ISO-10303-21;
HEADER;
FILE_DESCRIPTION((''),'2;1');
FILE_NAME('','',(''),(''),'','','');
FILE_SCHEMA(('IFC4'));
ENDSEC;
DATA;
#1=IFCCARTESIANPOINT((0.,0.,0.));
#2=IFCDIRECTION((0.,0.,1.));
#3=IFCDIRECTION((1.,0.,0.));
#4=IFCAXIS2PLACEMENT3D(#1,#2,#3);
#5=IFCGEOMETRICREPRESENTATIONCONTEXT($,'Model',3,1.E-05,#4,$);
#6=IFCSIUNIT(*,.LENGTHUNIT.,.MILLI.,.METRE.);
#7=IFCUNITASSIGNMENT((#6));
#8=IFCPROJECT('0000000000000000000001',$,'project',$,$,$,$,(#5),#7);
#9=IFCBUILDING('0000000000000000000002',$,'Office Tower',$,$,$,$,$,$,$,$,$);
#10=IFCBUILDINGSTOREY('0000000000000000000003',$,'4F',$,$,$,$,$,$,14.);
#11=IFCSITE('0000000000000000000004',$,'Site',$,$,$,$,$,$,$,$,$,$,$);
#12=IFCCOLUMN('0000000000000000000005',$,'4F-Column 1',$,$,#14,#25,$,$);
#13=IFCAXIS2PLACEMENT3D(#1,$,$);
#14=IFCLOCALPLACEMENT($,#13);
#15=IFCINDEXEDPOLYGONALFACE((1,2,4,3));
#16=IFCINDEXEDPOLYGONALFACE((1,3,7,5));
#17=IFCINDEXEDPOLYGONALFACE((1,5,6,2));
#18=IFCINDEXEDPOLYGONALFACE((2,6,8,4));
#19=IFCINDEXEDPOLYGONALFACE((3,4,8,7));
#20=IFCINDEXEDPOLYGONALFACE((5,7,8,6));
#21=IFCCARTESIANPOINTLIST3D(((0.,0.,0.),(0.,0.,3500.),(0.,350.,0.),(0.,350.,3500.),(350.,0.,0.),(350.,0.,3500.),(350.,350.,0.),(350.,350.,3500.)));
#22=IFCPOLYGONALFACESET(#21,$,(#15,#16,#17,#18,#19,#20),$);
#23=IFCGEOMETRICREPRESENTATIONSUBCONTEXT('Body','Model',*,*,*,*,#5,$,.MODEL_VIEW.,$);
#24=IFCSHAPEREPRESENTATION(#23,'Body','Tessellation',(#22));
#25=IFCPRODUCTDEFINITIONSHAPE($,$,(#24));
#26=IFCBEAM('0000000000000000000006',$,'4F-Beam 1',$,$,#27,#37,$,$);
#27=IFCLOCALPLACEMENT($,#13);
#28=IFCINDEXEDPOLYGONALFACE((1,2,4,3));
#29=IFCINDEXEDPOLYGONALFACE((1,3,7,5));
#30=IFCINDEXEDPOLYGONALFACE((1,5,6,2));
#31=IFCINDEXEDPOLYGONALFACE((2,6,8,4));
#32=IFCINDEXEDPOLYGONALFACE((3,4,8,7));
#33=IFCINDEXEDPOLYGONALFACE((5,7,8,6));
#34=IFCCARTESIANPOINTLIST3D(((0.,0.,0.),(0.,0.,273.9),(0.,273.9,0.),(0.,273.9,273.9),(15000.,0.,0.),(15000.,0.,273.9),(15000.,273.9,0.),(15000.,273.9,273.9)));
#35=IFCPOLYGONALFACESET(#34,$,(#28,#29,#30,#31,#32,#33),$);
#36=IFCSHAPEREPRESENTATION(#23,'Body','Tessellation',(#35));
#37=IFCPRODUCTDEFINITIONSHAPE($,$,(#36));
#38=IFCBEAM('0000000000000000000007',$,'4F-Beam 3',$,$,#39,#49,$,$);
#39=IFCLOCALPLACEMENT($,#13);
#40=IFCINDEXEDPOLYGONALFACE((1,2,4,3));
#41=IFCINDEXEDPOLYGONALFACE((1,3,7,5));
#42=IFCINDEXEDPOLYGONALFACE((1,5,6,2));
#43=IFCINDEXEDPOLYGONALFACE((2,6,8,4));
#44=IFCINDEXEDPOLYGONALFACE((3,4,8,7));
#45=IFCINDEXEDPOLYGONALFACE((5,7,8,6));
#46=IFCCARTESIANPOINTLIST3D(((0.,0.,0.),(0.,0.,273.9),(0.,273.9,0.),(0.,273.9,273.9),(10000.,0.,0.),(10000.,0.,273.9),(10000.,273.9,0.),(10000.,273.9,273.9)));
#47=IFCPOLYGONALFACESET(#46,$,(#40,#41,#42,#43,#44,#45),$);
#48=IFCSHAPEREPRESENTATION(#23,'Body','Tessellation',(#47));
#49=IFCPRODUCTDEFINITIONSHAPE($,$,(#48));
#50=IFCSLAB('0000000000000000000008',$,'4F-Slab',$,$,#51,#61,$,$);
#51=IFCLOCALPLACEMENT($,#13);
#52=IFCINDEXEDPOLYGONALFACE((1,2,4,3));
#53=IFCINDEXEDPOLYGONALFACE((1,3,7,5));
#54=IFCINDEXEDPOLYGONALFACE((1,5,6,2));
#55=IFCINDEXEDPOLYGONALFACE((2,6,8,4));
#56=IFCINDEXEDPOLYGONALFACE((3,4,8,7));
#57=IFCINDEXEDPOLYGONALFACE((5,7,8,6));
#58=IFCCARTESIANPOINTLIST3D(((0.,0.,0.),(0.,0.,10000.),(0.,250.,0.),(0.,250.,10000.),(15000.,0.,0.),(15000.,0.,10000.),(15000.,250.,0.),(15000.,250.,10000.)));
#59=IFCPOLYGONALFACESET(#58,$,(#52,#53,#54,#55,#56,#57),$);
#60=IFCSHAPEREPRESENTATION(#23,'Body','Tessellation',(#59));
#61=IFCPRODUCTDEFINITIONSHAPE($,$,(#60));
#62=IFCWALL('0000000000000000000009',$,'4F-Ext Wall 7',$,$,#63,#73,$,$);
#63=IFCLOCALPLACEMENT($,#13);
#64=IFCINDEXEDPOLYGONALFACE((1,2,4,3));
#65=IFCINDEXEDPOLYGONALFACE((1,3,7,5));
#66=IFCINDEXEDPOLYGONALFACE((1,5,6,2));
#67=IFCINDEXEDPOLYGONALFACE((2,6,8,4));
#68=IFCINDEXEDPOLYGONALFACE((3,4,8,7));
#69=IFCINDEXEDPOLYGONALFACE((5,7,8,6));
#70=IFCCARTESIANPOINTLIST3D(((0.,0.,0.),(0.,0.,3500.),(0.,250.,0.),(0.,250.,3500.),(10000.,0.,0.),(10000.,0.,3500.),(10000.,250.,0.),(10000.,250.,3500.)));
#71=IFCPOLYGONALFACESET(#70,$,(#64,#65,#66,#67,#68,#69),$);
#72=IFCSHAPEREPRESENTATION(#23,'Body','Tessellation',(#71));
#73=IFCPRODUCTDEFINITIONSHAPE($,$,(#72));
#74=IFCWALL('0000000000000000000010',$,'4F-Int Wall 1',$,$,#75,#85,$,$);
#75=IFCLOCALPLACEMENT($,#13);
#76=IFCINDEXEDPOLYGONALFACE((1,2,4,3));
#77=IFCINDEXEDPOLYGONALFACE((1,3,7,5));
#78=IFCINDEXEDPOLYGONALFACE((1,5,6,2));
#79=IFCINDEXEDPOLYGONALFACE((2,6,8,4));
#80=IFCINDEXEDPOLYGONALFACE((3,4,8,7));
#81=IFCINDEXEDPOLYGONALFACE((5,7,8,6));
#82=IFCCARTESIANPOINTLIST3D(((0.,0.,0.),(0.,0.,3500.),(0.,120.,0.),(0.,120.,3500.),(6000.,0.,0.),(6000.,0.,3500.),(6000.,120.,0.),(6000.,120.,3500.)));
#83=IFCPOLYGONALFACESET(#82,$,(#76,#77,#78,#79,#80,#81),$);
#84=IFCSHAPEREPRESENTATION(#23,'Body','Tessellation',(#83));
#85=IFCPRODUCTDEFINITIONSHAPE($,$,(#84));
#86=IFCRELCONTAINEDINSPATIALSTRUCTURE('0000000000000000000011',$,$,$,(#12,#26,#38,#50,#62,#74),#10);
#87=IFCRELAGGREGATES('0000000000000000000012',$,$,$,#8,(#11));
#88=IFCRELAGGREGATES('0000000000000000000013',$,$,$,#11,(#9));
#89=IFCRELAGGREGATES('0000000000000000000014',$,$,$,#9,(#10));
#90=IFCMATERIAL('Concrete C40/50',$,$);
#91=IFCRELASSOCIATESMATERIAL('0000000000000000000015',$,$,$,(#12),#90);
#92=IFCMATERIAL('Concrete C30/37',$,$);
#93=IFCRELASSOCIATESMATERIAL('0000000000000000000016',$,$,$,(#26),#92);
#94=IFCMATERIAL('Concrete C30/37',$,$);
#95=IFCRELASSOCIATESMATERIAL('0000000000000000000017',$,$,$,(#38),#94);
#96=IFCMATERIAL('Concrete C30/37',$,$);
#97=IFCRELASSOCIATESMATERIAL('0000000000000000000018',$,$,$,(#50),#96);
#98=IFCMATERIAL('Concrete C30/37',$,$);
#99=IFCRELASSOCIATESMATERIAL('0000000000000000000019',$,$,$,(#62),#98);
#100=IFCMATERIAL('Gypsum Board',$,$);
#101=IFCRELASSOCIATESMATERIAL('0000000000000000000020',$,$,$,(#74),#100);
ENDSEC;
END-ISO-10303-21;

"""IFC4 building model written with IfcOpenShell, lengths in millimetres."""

from ifc_helpers import new_model, si_unit, origin_with_axes, context, subcontext, project, spatial, indexed_curve, outline, extrude, material, element, save


model = new_model("IFC4")

# Units and contexts
model_context = context("Model", 3, precision=1e-05, world=origin_with_axes())
body_context = subcontext(model_context, "Body", "Model", "MODEL_VIEW")
ifc_project = project(units=[si_unit("LENGTHUNIT", "METRE", prefix="MILLI")], contexts=[model_context])

# Site, building, storey
site = spatial("IfcSite", under=ifc_project, Name="Site")
building = spatial("IfcBuilding", under=site, Name="Office Tower")
storey = spatial("IfcBuildingStorey", under=building, Name="4F", Elevation=14.0)

# Column
ifc_material_1 = material(Name="Concrete C40/50")
element("IfcColumn", 1, inside=storey, material=ifc_material_1, Name="4F-Column 1", context=body_context, shape_type="SweptSolid", body=[
    extrude(outline(indexed_curve([(0.0, 0.0), (0.0, 350.0), (350.0, 350.0), (350.0, 0.0), (0.0, 0.0)], self_intersect=False)), origin_with_axes(), (0.0, 0.0, 1.0), 3500.0),
])

# Beams
ifc_material_2 = material(Name="Concrete C30/37")
element("IfcBeam", 2, inside=storey, material=ifc_material_2, Name="4F-Beam 1", context=body_context, shape_type="SweptSolid", body=[
    extrude(outline(indexed_curve([(0.0, 0.0), (0.0, 273.9), (15000.0, 273.9), (15000.0, 0.0), (0.0, 0.0)], self_intersect=False)), origin_with_axes(), (0.0, 0.0, 1.0), 273.9),
])
ifc_material_3 = material(Name="Concrete C30/37")
element("IfcBeam", 3, inside=storey, material=ifc_material_3, Name="4F-Beam 3", context=body_context, shape_type="SweptSolid", body=[
    extrude(outline(indexed_curve([(0.0, 0.0), (0.0, 273.9), (10000.0, 273.9), (10000.0, 0.0), (0.0, 0.0)], self_intersect=False)), origin_with_axes(), (0.0, 0.0, 1.0), 273.9),
])

# Slab
ifc_material_4 = material(Name="Concrete C30/37")
element("IfcSlab", 4, inside=storey, material=ifc_material_4, Name="4F-Slab", context=body_context, shape_type="SweptSolid", body=[
    extrude(outline(indexed_curve([(0.0, 0.0), (0.0, 250.0), (15000.0, 250.0), (15000.0, 0.0), (0.0, 0.0)], self_intersect=False)), origin_with_axes(), (0.0, 0.0, 1.0), 10000.0),
])

# Walls
ifc_material_5 = material(Name="Concrete C30/37")
element("IfcWall", 5, inside=storey, material=ifc_material_5, Name="4F-Ext Wall 7", context=body_context, shape_type="SweptSolid", body=[
    extrude(outline(indexed_curve([(0.0, 0.0), (0.0, 250.0), (10000.0, 250.0), (10000.0, 0.0), (0.0, 0.0)], self_intersect=False)), origin_with_axes(), (0.0, 0.0, 1.0), 3500.0),
])
ifc_material_6 = material(Name="Gypsum Board")
element("IfcWall", 6, inside=storey, material=ifc_material_6, Name="4F-Int Wall 1", context=body_context, shape_type="SweptSolid", body=[
    extrude(outline(indexed_curve([(0.0, 0.0), (0.0, 120.0), (6000.0, 120.0), (6000.0, 0.0), (0.0, 0.0)], self_intersect=False)), origin_with_axes(), (0.0, 0.0, 1.0), 3500.0),
])

save(model, "model.ifc")
